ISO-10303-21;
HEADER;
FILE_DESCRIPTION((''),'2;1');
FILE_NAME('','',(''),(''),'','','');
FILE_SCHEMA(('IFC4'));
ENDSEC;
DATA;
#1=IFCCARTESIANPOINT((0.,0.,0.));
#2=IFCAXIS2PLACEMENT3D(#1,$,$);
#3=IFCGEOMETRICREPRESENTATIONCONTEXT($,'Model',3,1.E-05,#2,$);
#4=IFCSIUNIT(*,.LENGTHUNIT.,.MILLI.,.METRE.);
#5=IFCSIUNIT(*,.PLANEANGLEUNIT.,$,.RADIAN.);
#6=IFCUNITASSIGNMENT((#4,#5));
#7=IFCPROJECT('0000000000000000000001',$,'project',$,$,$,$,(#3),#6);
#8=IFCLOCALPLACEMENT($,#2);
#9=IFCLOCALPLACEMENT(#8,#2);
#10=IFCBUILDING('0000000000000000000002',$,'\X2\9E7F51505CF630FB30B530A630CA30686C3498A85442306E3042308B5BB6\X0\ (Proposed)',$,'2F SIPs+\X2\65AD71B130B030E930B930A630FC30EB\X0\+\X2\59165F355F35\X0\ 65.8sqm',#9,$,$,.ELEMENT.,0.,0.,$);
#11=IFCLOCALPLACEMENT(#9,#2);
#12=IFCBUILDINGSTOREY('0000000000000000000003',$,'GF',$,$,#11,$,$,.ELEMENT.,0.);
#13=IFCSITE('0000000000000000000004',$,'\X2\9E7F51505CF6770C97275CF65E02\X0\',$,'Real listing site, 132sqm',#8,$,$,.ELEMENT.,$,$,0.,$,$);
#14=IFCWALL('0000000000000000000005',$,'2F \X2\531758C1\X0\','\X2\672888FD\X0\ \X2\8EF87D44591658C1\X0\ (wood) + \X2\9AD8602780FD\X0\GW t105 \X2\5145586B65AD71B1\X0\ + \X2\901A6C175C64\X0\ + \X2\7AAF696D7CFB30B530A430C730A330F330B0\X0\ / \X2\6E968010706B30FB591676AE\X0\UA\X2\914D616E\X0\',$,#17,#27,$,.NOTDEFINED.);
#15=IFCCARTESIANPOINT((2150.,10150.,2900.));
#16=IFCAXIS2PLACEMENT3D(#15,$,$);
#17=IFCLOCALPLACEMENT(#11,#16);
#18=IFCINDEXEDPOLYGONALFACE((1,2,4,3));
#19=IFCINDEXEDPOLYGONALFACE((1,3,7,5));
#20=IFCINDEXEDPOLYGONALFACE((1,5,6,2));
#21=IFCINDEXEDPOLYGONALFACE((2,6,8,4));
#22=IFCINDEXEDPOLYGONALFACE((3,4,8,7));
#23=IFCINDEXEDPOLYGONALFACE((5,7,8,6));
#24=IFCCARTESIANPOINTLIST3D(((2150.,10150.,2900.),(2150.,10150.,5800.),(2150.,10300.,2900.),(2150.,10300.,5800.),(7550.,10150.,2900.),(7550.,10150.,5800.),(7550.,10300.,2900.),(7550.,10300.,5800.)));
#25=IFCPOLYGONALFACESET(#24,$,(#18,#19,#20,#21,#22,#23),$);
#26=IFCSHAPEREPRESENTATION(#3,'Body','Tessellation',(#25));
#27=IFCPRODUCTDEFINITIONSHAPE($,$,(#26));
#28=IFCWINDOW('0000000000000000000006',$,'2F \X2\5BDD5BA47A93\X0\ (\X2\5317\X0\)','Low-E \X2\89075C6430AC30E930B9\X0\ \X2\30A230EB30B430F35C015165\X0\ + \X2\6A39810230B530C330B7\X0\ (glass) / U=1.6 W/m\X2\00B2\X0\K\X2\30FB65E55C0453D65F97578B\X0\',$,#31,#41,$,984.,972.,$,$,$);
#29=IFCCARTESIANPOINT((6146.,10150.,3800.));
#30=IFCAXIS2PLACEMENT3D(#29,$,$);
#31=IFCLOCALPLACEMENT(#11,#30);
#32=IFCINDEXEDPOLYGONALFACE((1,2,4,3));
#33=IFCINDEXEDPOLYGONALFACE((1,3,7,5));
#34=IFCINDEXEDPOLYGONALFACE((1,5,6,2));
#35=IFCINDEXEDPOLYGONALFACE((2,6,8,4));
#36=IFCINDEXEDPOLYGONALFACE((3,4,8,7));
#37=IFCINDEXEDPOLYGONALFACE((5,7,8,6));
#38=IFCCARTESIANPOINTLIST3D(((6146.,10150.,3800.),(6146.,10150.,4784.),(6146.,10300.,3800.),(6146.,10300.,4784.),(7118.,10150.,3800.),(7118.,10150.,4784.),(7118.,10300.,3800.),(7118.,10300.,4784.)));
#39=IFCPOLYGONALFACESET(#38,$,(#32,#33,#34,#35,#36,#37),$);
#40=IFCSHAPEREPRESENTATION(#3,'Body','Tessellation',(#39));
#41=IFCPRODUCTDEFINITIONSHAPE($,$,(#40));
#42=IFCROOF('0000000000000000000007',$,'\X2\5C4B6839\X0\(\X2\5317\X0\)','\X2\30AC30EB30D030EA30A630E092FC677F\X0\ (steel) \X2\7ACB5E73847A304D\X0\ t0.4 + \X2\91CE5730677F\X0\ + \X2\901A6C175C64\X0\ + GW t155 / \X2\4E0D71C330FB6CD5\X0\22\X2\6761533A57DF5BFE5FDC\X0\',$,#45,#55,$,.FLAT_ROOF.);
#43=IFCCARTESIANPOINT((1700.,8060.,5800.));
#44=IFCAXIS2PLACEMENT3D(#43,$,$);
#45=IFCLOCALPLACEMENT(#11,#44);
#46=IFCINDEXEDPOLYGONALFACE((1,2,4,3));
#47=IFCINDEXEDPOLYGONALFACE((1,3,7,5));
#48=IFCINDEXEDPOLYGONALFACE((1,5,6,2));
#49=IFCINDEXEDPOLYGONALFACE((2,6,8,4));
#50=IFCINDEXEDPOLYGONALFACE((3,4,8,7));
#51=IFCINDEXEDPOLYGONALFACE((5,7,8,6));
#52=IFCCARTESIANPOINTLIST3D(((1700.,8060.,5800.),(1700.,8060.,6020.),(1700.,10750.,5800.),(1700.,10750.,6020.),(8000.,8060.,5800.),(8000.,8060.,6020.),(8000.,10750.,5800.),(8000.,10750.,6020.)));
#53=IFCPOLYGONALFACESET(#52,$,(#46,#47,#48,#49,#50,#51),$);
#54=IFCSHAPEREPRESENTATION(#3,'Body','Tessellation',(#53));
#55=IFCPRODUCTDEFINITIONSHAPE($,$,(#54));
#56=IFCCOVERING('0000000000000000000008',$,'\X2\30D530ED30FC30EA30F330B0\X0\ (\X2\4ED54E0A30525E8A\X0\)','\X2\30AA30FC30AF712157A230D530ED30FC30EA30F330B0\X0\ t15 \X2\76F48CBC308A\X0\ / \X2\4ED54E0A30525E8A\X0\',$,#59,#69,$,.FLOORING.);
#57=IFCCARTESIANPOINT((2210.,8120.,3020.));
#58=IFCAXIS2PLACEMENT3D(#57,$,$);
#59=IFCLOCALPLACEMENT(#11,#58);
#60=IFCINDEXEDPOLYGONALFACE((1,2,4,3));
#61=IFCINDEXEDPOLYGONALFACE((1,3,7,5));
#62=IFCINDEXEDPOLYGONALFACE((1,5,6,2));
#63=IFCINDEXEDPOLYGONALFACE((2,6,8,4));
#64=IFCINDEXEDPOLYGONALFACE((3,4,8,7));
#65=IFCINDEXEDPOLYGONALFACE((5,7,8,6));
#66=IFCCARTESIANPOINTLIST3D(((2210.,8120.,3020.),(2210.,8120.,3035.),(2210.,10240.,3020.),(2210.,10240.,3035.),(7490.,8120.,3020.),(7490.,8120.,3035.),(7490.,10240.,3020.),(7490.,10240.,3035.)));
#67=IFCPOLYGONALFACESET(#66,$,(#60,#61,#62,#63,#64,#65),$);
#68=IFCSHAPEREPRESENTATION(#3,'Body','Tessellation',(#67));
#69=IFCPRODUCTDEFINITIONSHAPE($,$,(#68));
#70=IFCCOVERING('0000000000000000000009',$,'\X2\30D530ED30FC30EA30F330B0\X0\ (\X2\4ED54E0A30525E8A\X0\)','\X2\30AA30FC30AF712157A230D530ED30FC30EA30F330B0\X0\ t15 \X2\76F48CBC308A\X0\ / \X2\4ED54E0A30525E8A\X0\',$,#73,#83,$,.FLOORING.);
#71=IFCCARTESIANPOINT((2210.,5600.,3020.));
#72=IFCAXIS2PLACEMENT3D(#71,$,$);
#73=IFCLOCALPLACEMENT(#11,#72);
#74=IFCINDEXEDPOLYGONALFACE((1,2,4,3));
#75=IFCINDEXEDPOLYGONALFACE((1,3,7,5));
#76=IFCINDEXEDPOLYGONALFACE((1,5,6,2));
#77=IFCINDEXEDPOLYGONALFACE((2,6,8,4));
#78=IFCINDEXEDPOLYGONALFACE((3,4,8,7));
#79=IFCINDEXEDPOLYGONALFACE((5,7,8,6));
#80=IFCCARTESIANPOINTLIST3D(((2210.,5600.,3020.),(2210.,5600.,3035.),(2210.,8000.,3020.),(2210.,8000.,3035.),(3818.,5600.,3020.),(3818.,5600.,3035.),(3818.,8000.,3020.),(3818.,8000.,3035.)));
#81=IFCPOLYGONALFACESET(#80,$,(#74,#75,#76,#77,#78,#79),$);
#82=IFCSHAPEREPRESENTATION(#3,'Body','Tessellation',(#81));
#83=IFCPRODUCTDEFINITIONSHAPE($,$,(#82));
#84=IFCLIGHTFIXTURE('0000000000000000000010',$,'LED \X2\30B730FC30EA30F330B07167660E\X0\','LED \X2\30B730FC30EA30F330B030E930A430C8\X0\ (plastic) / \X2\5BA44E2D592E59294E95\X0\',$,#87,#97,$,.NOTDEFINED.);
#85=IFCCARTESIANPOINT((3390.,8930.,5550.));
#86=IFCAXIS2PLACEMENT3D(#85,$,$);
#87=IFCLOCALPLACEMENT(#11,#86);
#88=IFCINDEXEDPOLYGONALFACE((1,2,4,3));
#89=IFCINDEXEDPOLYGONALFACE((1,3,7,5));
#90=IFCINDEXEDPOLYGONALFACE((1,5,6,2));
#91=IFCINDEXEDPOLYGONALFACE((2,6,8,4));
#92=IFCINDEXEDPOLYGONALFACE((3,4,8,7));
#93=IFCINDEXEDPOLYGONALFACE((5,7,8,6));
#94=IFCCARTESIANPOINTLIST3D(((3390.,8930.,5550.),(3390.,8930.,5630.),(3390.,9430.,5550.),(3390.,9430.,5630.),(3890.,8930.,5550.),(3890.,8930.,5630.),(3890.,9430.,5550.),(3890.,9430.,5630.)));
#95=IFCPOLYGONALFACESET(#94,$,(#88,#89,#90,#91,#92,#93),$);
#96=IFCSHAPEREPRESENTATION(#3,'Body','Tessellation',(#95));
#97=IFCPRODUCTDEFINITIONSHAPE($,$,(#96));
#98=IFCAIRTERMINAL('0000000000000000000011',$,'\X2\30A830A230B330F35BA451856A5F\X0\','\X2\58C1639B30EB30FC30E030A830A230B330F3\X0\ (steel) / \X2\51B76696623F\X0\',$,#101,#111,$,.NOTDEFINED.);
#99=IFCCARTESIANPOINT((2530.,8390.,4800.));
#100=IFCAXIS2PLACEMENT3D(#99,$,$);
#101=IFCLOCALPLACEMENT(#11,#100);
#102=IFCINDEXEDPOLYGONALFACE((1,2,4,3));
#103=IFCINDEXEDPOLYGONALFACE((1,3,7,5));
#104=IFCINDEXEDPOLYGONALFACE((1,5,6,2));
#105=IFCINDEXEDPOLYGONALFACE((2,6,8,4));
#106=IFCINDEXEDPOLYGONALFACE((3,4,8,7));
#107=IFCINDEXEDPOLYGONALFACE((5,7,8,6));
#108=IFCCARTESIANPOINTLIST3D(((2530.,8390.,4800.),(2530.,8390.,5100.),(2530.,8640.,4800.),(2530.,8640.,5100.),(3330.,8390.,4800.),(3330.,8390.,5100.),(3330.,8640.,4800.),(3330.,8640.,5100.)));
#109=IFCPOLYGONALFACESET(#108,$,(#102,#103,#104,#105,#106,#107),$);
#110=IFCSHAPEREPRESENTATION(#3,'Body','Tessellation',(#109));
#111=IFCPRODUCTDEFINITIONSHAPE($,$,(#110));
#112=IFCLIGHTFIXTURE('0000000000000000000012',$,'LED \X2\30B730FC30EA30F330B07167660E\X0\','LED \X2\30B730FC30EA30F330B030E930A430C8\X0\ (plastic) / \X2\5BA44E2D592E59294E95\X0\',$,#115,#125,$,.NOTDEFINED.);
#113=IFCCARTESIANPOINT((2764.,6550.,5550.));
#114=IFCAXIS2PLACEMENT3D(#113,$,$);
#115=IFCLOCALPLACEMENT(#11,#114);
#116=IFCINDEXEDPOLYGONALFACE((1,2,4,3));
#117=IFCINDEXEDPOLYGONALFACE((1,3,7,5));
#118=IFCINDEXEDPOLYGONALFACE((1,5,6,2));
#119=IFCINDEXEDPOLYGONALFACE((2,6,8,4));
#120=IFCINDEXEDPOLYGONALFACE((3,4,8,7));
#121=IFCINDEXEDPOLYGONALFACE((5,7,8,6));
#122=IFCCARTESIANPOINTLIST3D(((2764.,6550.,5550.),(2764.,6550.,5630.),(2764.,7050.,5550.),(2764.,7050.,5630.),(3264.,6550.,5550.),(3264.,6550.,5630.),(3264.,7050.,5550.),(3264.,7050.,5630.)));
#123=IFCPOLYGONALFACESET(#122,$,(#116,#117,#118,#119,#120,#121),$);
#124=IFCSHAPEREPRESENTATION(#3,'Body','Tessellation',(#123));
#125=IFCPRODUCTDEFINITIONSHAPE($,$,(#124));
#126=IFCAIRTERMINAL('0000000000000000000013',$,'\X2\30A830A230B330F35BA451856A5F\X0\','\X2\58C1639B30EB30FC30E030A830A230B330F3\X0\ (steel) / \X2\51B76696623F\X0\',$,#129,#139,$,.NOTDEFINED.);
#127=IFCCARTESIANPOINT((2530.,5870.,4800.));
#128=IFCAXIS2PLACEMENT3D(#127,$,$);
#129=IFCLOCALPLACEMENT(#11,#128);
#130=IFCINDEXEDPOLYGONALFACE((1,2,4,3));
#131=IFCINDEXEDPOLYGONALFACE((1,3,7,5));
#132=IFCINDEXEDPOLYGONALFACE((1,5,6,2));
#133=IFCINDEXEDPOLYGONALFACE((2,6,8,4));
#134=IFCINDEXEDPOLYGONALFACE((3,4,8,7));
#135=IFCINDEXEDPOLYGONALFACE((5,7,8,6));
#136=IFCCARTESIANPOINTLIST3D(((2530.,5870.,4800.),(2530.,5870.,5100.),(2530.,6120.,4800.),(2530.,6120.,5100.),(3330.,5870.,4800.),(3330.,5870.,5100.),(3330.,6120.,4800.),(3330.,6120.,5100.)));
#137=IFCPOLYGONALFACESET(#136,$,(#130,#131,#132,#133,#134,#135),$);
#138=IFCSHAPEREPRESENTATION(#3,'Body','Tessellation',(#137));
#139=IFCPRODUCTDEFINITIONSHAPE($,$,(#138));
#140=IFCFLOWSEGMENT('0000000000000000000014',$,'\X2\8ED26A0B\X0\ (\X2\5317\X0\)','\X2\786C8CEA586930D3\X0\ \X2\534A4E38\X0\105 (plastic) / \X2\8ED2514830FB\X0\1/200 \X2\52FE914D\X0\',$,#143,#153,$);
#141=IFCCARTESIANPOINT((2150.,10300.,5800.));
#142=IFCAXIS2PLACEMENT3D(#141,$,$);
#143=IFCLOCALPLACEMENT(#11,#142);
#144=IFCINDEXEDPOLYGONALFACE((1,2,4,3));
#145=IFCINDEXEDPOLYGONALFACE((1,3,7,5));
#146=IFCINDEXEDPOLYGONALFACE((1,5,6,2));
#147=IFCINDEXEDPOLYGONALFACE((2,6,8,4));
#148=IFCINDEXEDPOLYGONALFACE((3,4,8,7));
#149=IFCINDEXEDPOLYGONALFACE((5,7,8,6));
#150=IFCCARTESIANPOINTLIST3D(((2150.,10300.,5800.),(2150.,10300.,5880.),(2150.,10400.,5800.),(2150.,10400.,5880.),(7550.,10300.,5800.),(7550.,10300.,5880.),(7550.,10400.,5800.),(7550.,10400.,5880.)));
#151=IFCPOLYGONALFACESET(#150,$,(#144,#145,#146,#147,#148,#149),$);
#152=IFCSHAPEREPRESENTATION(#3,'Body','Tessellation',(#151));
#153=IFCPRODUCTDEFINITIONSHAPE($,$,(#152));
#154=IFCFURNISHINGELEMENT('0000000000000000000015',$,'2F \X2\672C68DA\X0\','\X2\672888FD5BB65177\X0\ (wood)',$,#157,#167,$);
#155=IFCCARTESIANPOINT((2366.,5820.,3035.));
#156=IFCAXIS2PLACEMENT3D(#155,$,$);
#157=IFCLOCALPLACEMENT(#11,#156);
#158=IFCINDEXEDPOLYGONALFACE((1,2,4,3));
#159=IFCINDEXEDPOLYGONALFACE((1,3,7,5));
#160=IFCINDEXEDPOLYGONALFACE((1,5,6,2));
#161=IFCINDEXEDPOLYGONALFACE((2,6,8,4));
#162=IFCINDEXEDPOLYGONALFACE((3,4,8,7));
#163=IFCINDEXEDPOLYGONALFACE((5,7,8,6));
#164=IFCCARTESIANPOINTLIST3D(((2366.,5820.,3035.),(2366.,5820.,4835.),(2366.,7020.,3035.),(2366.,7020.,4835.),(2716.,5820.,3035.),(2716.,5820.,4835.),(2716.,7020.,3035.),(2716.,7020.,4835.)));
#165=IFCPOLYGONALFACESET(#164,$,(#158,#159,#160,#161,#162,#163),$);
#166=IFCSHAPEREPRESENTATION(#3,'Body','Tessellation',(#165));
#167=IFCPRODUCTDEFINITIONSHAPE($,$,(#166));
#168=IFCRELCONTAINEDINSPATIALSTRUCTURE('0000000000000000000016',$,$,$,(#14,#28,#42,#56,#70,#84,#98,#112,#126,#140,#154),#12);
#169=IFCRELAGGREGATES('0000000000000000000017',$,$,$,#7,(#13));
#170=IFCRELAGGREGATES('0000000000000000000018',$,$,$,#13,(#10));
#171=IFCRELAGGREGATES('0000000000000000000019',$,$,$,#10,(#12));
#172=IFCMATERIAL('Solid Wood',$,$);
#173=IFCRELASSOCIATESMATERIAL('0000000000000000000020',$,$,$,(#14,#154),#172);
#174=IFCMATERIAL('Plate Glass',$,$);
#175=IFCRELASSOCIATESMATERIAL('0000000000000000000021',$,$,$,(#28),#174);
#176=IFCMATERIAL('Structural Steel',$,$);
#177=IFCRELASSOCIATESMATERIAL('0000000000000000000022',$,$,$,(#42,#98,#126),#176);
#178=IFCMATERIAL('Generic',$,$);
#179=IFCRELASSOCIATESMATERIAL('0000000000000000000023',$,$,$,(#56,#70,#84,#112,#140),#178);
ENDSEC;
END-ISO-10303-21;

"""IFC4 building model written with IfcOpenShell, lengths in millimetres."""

from ifc_helpers import new_model, si_unit, frame, frame_2d, origin, place, context, project, spatial, rectangle, extrude, material, element, fill, save


model = new_model("IFC4")

# Units and contexts
model_context = context("Model", 3, precision=1e-05, world=origin())
ifc_project = project(units=[si_unit("LENGTHUNIT", "METRE", prefix="MILLI"), si_unit("PLANEANGLEUNIT", "RADIAN")], contexts=[model_context])

# Site, building, storey
site_placement = place(None, origin())
site = spatial("IfcSite", under=ifc_project, at=site_placement, Name="鹿児島県霧島市", ObjectType="Real listing site, 132sqm", CompositionType="ELEMENT", RefElevation=0.0)
building_placement = place(site_placement, origin())
building = spatial("IfcBuilding", under=site, at=building_placement, Name="鹿児島・サウナと水風呂のある家 (Proposed)", ObjectType="2F SIPs+断熱グラスウール+外張張 65.8sqm", CompositionType="ELEMENT", ElevationOfRefHeight=0.0, ElevationOfTerrain=0.0)
storey_placement = place(building_placement, origin())
storey = spatial("IfcBuildingStorey", under=building, at=storey_placement, Name="GF", CompositionType="ELEMENT", Elevation=0.0)

# Shared definitions
ifc_material_1 = material(Name="Solid Wood")

# Wall, opening, window
wall_placement = place(storey_placement, frame((2150.0, 10150.0, 2900.0)))
wall = element("IfcWall", 1, at=wall_placement, inside=storey, material=ifc_material_1, Name="2F 北壁", Description="木製 軸組外壁 (wood) + 高性能GW t105 充填断熱 + 通気層 + 窯業系サイディング / 準耐火・外皮UA配慮", PredefinedType="NOTDEFINED", context=model_context, shape_type="SweptSolid", body=[
    extrude(rectangle(XDim=5400.0, YDim=150.0, at=frame_2d((2700.0, 75.0))), frame((2150.0, 10150.0, 2900.0)), (0.0, 0.0, 1.0), 2900.0),
])
opening_placement = place(storey_placement, frame((6146.0, 10150.0, 3800.0)))
opening = element("IfcOpeningElement", 2, at=opening_placement, cuts=wall, PredefinedType="NOTDEFINED", context=model_context, shape_type="SweptSolid", body=[
    extrude(rectangle(XDim=972.0, YDim=150.0, at=frame_2d((486.0, 75.0))), frame((6146.0, 10150.0, 3800.0)), (0.0, 0.0, 1.0), 984.0),
])
ifc_material_2 = material(Name="Plate Glass")
window_placement = place(storey_placement, frame((6146.0, 10150.0, 3800.0)))
window = element("IfcWindow", 3, at=window_placement, inside=storey, material=ifc_material_2, Name="2F 寝室窓 (北)", Description="Low-E 複層ガラス アルゴン封入 + 樹脂サッシ (glass) / U=1.6 W/m²K・日射取得型", OverallHeight=984.0, OverallWidth=972.0, context=model_context, shape_type="SweptSolid", body=[
    extrude(rectangle(XDim=972.0, YDim=150.0, at=frame_2d((486.0, 75.0))), frame((6146.0, 10150.0, 3800.0)), (0.0, 0.0, 1.0), 984.0),
])
fill(opening, window)

# Roof
ifc_material_3 = material(Name="Structural Steel")
for number, where, name in (
    (4, (1700.0, 8060.0, 5800.0), "屋根(北)"),
):
    element("IfcRoof", number, at=place(storey_placement, frame(where)), inside=storey, material=ifc_material_3, Name=name, Description="ガルバリウム鋼板 (steel) 立平葺き t0.4 + 野地板 + 通気層 + GW t155 / 不燃・法22条区域対応", PredefinedType="FLAT_ROOF", context=model_context, shape_type="SweptSolid", body=[
        extrude(rectangle(XDim=6300.0, YDim=2690.0, at=frame_2d((3150.0, 1345.0))), frame((1700.0, 8060.0, 5800.0)), (0.0, 0.0, 1.0), 220.0),
    ])

# Coverings
ifc_material_4 = material(Name="Generic")
covering_1_placement = place(storey_placement, frame((2210.0, 8120.0, 3020.0)))
element("IfcCovering", 5, at=covering_1_placement, inside=storey, material=ifc_material_4, Name="フローリング (仕上げ床)", Description="オーク無垢フローリング t15 直貼り / 仕上げ床", PredefinedType="FLOORING", context=model_context, shape_type="SweptSolid", body=[
    extrude(rectangle(XDim=5280.0, YDim=2120.0, at=frame_2d((2640.0, 1060.0))), frame((2210.0, 8120.0, 3020.0)), (0.0, 0.0, 1.0), 15.0),
])
covering_2_placement = place(storey_placement, frame((2210.0, 5600.0, 3020.0)))
element("IfcCovering", 6, at=covering_2_placement, inside=storey, material=ifc_material_4, Name="フローリング (仕上げ床)", Description="オーク無垢フローリング t15 直貼り / 仕上げ床", PredefinedType="FLOORING", context=model_context, shape_type="SweptSolid", body=[
    extrude(rectangle(XDim=1608.0, YDim=2400.0, at=frame_2d((804.0, 1200.0))), frame((2210.0, 5600.0, 3020.0)), (0.0, 0.0, 1.0), 15.0),
])

# Light fixture
light_fixture_1_placement = place(storey_placement, frame((3390.0, 8930.0, 5550.0)))
element("IfcLightFixture", 7, at=light_fixture_1_placement, inside=storey, material=ifc_material_4, Name="LED シーリング照明", Description="LED シーリングライト (plastic) / 室中央天井", PredefinedType="NOTDEFINED", context=model_context, shape_type="SweptSolid", body=[
    extrude(rectangle(XDim=500.0, YDim=500.0, at=frame_2d((250.0, 250.0))), frame((3390.0, 8930.0, 5550.0)), (0.0, 0.0, 1.0), 80.0),
])

# Air terminal
air_terminal_1_placement = place(storey_placement, frame((2530.0, 8390.0, 4800.0)))
element("IfcAirTerminal", 8, at=air_terminal_1_placement, inside=storey, material=ifc_material_3, Name="エアコン室内機", Description="壁掛ルームエアコン (steel) / 冷暖房", PredefinedType="NOTDEFINED", context=model_context, shape_type="SweptSolid", body=[
    extrude(rectangle(XDim=800.0, YDim=250.0, at=frame_2d((400.0, 125.0))), frame((2530.0, 8390.0, 4800.0)), (0.0, 0.0, 1.0), 300.0),
])

# Light fixture
light_fixture_2_placement = place(storey_placement, frame((2764.0, 6550.0, 5550.0)))
element("IfcLightFixture", 9, at=light_fixture_2_placement, inside=storey, material=ifc_material_4, Name="LED シーリング照明", Description="LED シーリングライト (plastic) / 室中央天井", PredefinedType="NOTDEFINED", context=model_context, shape_type="SweptSolid", body=[
    extrude(rectangle(XDim=500.0, YDim=500.0, at=frame_2d((250.0, 250.0))), frame((2764.0, 6550.0, 5550.0)), (0.0, 0.0, 1.0), 80.0),
])

# Air terminal
air_terminal_2_placement = place(storey_placement, frame((2530.0, 5870.0, 4800.0)))
element("IfcAirTerminal", 10, at=air_terminal_2_placement, inside=storey, material=ifc_material_3, Name="エアコン室内機", Description="壁掛ルームエアコン (steel) / 冷暖房", PredefinedType="NOTDEFINED", context=model_context, shape_type="SweptSolid", body=[
    extrude(rectangle(XDim=800.0, YDim=250.0, at=frame_2d((400.0, 125.0))), frame((2530.0, 5870.0, 4800.0)), (0.0, 0.0, 1.0), 300.0),
])

# Flow segment
flow_segment_placement = place(storey_placement, frame((2150.0, 10300.0, 5800.0)))
element("IfcFlowSegment", 11, at=flow_segment_placement, inside=storey, material=ifc_material_4, Name="軒樋 (北)", Description="硬質塩ビ 半丸105 (plastic) / 軒先・1/200 勾配", context=model_context, shape_type="SweptSolid", body=[
    extrude(rectangle(XDim=5400.0, YDim=100.0, at=frame_2d((2700.0, 50.0))), frame((2150.0, 10300.0, 5800.0)), (0.0, 0.0, 1.0), 80.0),
])

# Furnishing element
furnishing_placement = place(storey_placement, frame((2366.0, 5820.0, 3035.0)))
element("IfcFurnishingElement", 12, at=furnishing_placement, inside=storey, material=ifc_material_1, Name="2F 本棚", Description="木製家具 (wood)", context=model_context, shape_type="SweptSolid", body=[
    extrude(rectangle(XDim=350.0, YDim=1200.0, at=frame_2d((175.0, 600.0))), frame((2366.0, 5820.0, 3035.0)), (0.0, 0.0, 1.0), 1800.0),
])

save(model, "model.ifc")
